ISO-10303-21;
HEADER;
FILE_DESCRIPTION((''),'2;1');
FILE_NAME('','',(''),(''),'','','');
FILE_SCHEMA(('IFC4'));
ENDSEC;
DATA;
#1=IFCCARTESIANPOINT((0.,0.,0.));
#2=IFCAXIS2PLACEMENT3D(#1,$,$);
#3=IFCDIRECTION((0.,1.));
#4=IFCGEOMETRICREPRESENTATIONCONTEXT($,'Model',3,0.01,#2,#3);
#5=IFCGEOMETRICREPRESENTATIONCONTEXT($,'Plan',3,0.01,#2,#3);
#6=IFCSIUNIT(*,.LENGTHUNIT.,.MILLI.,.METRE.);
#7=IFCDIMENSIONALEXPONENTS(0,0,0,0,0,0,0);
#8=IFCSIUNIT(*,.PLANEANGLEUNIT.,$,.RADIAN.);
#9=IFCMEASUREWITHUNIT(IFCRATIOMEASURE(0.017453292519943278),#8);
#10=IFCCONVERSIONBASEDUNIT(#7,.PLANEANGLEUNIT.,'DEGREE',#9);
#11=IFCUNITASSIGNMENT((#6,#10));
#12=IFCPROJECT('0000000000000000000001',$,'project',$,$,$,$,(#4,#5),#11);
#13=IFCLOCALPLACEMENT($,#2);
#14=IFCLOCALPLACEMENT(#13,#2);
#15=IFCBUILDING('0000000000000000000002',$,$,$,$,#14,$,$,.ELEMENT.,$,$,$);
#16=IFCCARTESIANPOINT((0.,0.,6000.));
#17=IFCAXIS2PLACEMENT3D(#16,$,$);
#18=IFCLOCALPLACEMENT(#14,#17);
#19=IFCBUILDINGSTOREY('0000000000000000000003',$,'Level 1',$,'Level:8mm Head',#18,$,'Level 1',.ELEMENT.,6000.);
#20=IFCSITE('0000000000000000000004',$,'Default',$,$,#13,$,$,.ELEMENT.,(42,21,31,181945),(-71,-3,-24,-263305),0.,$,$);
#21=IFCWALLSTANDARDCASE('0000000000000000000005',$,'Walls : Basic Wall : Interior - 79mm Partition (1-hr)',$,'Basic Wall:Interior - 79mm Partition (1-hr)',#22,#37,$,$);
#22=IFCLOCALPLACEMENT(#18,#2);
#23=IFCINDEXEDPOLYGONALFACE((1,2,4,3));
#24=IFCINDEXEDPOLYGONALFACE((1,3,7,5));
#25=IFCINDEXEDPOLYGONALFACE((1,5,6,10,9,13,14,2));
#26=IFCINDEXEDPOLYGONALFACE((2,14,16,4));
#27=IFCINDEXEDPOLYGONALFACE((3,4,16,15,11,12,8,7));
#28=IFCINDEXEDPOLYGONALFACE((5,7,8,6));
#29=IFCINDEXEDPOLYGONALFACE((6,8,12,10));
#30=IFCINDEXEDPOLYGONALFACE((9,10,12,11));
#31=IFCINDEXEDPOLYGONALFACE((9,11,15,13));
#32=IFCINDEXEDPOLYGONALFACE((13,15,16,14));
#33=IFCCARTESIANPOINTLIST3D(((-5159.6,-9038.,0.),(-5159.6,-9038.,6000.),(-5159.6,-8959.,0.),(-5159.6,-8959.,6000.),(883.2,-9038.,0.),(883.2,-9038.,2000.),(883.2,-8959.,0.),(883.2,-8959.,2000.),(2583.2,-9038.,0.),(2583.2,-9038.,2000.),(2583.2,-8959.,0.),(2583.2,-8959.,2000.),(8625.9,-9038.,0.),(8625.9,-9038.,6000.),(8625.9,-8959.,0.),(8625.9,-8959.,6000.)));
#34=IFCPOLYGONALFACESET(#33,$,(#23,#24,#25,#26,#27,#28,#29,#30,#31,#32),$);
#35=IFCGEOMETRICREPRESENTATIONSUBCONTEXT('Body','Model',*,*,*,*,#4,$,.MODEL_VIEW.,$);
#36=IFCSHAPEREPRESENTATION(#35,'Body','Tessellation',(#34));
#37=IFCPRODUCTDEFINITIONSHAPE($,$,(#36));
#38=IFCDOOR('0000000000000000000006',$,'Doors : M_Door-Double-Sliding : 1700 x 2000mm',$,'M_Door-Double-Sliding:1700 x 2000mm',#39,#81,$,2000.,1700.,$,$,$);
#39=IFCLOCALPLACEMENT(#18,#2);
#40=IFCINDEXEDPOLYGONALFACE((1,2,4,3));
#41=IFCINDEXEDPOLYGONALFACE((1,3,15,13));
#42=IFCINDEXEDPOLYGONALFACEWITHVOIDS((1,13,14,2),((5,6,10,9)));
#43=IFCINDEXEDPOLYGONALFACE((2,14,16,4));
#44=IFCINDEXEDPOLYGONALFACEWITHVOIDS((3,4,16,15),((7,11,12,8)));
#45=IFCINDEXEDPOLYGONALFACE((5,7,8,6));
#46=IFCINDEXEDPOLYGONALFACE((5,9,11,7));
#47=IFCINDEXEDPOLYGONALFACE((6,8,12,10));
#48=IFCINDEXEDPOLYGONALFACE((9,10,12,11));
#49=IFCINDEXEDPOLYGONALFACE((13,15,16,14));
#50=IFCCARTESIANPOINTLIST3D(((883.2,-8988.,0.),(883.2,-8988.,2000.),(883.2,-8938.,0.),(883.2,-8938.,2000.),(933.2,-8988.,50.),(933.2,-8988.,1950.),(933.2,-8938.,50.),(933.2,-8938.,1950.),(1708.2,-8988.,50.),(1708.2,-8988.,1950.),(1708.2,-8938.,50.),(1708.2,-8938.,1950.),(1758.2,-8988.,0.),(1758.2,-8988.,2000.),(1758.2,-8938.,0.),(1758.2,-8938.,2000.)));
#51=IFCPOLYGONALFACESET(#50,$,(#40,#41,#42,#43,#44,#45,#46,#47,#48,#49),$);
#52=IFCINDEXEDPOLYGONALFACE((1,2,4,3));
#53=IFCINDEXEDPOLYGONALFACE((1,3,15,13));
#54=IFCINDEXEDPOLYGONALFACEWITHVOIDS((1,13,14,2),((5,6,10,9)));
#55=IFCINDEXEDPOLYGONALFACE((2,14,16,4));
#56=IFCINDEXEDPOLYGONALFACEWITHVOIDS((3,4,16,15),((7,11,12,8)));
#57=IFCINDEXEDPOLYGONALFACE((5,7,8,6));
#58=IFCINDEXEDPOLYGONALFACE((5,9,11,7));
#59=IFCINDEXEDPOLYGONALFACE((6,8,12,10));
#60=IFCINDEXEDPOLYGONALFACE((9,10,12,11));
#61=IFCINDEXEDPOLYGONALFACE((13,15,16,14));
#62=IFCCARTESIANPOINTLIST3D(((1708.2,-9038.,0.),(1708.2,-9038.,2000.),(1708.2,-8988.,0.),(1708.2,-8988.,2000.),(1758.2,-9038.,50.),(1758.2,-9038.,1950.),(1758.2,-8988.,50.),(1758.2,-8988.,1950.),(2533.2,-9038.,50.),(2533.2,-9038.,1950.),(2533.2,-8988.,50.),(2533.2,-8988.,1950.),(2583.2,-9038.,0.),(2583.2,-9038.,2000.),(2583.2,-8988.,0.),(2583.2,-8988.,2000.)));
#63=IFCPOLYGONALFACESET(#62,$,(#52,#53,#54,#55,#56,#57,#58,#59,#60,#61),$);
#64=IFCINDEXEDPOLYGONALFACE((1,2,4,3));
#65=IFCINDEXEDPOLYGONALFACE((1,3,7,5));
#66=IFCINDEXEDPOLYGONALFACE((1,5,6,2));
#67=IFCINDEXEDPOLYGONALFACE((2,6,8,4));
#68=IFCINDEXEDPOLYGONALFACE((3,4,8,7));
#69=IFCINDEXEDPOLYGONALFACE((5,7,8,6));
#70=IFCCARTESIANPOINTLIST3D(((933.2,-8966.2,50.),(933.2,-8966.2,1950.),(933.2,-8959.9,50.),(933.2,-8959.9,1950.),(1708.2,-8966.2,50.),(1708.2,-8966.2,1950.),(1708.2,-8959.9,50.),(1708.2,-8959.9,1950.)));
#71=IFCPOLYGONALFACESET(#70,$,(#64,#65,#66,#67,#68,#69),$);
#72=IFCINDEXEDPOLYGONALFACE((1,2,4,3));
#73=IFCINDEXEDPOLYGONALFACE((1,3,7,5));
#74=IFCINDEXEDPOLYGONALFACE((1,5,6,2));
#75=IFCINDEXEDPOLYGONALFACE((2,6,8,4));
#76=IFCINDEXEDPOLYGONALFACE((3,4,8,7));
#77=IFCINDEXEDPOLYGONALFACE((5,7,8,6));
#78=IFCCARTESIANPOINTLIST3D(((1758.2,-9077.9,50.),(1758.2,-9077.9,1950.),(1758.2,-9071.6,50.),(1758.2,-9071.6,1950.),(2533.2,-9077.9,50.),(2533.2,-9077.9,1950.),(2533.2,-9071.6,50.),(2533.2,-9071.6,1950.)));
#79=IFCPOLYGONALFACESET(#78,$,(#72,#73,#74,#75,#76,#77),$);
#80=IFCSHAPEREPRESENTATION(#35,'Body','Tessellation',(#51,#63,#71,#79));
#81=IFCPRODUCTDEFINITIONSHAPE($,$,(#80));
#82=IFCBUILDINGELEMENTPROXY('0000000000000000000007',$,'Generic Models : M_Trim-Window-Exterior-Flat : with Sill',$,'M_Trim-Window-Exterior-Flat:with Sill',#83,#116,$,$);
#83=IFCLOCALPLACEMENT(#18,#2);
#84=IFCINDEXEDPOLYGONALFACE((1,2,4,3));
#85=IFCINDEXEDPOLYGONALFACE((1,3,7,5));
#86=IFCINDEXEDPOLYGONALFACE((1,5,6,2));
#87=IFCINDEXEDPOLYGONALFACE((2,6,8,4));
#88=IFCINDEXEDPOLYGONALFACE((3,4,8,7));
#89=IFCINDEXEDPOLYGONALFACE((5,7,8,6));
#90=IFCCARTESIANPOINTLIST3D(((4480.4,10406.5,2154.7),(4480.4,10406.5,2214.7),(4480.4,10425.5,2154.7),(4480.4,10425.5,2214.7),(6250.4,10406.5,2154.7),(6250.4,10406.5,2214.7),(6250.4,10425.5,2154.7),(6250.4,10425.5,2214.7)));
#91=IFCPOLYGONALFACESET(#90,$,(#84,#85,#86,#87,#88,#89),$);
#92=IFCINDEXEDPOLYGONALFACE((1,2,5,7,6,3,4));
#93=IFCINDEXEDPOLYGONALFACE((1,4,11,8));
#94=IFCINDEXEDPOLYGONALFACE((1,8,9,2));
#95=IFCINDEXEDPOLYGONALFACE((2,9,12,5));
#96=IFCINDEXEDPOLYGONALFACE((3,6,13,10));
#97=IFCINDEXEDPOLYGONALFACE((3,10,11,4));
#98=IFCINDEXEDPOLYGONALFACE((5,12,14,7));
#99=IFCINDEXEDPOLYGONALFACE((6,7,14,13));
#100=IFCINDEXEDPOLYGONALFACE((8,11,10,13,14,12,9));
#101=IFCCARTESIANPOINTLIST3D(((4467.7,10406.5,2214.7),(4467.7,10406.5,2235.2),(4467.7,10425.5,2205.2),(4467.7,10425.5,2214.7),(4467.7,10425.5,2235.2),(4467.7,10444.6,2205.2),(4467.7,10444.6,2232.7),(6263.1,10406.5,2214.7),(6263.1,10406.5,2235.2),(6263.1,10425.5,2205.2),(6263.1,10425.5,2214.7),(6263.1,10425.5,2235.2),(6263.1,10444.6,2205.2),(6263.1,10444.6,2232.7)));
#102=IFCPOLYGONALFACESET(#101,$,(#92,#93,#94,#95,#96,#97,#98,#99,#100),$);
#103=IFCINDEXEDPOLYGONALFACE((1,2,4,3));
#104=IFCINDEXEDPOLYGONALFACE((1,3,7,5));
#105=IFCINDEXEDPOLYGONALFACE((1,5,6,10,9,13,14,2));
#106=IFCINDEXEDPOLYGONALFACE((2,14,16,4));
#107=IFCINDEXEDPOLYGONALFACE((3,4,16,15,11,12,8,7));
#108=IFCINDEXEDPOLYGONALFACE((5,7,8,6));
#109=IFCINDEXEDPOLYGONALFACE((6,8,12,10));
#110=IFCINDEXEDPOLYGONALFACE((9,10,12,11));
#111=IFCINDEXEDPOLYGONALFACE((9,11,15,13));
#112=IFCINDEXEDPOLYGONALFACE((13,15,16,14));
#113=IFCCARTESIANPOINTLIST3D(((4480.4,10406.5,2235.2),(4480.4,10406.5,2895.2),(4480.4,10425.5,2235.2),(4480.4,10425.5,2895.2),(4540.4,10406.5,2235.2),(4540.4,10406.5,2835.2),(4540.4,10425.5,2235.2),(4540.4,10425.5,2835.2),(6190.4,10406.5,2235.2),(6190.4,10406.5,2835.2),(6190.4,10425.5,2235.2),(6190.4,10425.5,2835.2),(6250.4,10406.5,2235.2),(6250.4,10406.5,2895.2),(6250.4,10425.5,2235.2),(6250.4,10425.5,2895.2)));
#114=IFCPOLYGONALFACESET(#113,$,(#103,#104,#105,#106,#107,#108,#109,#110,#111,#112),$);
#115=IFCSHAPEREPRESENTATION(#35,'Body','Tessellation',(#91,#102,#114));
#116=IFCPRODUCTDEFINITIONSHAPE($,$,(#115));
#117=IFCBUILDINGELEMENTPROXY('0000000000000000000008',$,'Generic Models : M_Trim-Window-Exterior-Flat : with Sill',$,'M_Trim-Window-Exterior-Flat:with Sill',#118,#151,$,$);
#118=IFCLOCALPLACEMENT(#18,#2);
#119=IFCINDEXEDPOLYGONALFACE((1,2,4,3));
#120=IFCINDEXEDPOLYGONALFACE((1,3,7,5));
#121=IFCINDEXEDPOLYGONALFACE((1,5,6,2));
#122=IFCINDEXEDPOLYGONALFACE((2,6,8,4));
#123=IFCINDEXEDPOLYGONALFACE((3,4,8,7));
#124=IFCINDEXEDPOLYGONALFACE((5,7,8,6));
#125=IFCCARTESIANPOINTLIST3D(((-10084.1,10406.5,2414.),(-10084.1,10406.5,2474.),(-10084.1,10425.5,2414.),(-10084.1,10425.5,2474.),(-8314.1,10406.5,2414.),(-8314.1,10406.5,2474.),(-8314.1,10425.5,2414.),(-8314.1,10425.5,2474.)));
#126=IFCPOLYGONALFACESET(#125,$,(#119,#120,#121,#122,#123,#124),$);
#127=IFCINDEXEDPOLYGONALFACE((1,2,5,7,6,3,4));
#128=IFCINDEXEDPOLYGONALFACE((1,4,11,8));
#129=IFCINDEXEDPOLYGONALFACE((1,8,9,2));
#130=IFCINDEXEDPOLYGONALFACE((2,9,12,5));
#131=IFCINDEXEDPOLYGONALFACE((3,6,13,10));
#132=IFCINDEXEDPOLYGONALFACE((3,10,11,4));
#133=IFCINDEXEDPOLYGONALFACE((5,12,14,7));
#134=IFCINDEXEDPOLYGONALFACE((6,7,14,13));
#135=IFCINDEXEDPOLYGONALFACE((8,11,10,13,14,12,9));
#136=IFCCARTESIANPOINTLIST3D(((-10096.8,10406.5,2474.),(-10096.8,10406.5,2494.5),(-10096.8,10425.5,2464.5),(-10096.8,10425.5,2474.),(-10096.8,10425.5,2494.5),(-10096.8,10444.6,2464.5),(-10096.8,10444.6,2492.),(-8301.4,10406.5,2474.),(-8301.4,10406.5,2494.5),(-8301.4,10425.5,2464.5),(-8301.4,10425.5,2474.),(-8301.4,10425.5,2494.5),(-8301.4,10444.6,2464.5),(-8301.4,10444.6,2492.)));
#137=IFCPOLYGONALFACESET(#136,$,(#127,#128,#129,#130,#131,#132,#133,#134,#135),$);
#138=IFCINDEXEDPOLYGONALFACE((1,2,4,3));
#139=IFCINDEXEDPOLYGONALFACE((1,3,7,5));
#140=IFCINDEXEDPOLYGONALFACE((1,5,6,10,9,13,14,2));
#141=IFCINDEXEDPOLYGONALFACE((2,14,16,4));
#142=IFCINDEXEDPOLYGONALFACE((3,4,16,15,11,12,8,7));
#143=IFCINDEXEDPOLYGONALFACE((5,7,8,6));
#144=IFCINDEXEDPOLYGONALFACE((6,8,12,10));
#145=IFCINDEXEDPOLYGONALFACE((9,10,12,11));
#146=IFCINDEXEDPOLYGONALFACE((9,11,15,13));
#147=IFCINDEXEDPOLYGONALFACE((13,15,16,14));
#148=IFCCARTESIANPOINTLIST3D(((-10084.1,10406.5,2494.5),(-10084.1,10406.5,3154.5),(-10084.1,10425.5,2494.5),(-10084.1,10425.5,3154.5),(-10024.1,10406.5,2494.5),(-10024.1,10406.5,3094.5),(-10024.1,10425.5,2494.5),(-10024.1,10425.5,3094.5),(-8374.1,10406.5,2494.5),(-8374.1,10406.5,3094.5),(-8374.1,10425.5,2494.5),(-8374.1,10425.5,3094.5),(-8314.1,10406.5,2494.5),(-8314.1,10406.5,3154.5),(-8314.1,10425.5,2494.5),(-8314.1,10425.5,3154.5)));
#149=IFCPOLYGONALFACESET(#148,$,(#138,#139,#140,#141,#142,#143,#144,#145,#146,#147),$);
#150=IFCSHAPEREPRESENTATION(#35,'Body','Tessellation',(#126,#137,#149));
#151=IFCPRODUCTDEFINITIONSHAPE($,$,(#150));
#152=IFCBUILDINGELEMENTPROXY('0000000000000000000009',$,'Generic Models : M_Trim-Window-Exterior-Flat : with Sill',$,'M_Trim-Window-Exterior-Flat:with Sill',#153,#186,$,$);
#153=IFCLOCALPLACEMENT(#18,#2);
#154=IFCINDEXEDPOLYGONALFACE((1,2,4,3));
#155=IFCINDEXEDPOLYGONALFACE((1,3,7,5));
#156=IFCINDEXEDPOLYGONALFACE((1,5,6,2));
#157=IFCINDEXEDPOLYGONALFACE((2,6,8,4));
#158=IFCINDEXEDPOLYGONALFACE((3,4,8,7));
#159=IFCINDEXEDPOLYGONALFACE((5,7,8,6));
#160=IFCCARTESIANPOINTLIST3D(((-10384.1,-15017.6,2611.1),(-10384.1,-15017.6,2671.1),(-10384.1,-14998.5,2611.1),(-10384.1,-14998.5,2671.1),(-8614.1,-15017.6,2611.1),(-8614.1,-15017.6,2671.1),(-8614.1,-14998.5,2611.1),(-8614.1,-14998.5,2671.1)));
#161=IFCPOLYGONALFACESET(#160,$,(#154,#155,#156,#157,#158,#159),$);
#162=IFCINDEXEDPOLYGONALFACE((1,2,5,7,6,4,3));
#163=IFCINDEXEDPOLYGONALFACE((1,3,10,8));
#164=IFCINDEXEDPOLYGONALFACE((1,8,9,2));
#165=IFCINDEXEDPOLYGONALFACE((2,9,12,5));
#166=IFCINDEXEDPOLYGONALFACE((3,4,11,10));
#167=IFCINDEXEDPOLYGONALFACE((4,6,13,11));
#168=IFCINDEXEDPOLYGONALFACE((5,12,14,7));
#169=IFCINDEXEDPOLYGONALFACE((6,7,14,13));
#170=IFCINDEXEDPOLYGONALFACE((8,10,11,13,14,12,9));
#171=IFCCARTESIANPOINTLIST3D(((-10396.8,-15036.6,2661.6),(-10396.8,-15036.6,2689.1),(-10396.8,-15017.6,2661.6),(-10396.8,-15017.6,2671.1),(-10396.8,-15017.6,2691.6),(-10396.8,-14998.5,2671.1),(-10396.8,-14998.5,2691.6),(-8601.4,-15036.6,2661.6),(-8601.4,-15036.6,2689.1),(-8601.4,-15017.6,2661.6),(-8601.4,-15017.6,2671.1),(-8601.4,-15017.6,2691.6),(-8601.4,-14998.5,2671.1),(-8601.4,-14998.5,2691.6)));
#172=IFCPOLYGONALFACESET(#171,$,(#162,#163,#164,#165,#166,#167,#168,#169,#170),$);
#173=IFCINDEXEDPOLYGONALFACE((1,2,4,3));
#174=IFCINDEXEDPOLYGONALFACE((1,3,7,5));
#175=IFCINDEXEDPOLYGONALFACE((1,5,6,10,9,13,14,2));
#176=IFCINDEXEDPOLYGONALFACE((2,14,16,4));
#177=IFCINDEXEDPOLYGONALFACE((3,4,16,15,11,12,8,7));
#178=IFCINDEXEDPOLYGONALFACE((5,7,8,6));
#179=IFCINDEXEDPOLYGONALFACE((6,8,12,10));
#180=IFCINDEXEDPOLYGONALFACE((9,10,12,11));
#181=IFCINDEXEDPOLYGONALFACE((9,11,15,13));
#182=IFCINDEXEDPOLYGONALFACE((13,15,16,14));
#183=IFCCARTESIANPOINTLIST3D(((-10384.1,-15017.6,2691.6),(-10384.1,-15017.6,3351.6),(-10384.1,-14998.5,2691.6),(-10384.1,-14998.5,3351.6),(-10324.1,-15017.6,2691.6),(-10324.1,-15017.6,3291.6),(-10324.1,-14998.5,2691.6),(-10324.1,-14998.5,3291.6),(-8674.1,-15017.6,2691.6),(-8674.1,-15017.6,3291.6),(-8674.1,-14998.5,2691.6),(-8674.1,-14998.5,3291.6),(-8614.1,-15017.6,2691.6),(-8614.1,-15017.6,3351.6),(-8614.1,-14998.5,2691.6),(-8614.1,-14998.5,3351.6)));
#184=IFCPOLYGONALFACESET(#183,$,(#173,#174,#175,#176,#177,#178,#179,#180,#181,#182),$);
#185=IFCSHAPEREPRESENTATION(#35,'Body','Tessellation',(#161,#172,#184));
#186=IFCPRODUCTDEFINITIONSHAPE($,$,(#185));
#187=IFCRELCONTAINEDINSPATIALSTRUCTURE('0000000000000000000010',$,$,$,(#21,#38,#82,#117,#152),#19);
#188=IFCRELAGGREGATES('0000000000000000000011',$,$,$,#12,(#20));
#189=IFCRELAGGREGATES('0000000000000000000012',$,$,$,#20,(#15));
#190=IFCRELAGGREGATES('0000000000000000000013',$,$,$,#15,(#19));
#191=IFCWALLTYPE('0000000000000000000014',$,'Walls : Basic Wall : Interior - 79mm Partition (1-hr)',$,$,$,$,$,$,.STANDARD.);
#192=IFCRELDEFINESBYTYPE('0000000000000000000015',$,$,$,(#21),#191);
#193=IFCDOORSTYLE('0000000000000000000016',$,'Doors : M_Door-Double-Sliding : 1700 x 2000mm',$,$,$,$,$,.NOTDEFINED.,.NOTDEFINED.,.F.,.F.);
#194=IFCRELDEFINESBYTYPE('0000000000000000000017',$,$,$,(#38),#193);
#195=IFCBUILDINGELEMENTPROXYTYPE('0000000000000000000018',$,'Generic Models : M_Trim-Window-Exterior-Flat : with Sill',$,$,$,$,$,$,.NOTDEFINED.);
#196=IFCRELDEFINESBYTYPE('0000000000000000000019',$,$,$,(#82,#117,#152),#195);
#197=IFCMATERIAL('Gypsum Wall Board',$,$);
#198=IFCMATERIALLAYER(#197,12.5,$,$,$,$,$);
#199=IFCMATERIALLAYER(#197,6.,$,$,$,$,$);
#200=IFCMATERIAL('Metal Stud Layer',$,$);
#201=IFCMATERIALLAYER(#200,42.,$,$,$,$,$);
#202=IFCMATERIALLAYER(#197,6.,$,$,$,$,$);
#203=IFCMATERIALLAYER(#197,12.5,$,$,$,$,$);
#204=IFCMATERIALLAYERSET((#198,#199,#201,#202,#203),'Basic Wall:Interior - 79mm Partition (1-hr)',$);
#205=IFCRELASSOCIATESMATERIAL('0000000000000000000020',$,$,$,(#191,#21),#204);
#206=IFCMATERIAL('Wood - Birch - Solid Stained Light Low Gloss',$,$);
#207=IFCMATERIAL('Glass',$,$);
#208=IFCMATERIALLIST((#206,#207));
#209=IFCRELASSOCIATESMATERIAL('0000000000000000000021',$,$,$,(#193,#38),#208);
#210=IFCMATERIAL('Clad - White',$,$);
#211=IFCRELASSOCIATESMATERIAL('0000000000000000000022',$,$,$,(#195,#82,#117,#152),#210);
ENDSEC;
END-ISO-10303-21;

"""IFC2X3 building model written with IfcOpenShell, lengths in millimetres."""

from ifc_helpers import new_model, entity, si_unit, converted_unit, direction, frame, frame_2d, origin, origin_2d_with_axis, place, context, subcontext, project, spatial, polyline, rectangle, outline, extrude, source, transform, mapped, material, material_list, layer, layer_set, layer_usage, type_object, type_shapes, element, fill, save


model = new_model("IFC2X3")

# Units and contexts
model_context = context("Model", 3, precision=0.01, world=origin(), true_north=direction((0.0, 1.0)))
plan_context = context("Plan", 3, precision=0.01, world=origin(), true_north=direction((0.0, 1.0)))
body_context = subcontext(model_context, "Body", "Model", "MODEL_VIEW")
ifc_project = project(units=[si_unit("LENGTHUNIT", "METRE", prefix="MILLI"), converted_unit("PLANEANGLEUNIT", "DEGREE", entity("IfcRatioMeasure", 0.017453292519943278), si_unit("PLANEANGLEUNIT", "RADIAN"), dimensions=[0, 0, 0, 0, 0, 0, 0])], contexts=[model_context, plan_context])

# Site, building, storey
site_placement = place(None, origin())
site = spatial("IfcSite", under=ifc_project, at=site_placement, Name="Default", CompositionType="ELEMENT", RefLatitude=(42, 21, 31, 181945), RefLongitude=(-71, -3, -24, -263305), RefElevation=0.0)
building_placement = place(site_placement, origin())
building = spatial("IfcBuilding", under=site, at=building_placement, CompositionType="ELEMENT")
storey_placement = place(building_placement, frame((0.0, 0.0, 6000.0)))
storey = spatial("IfcBuildingStorey", under=building, at=storey_placement, Name="Level 1", ObjectType="Level:8mm Head", LongName="Level 1", CompositionType="ELEMENT", Elevation=6000.0)

# Shared definitions
ifc_material_1 = material(Name="Gypsum Wall Board")
ifc_layer_1 = layer(ifc_material_1, 12.5)
ifc_layer_2 = layer(ifc_material_1, 6.0)
ifc_material_2 = material(Name="Metal Stud Layer")
ifc_layer_3 = layer(ifc_material_2, 42.0)
ifc_layer_4 = layer(ifc_material_1, 6.0)
ifc_layer_5 = layer(ifc_material_1, 12.5)
ifc_layer_set_1 = layer_set([ifc_layer_1, ifc_layer_2, ifc_layer_3, ifc_layer_4, ifc_layer_5], Name="Basic Wall:Interior - 79mm Partition (1-hr)")
ifc_layer_usage_1 = layer_usage(ifc_layer_set_1, "AXIS2", "NEGATIVE", 39.5)
wall_type = type_object("IfcWallType", Name="Walls : Basic Wall : Interior - 79mm Partition (1-hr)", PredefinedType="STANDARD", material=ifc_layer_set_1)

# Wall, opening, door
ifc_material_3 = material(Name="Wood - Birch - Solid Stained Light Low Gloss")
ifc_material_4 = material(Name="Glass")
ifc_material_list = material_list([ifc_material_3, ifc_material_4])
door_style = type_object("IfcDoorStyle", Name="Doors : M_Door-Double-Sliding : 1700 x 2000mm", ConstructionType="NOTDEFINED", OperationType="NOTDEFINED", ParameterTakesPrecedence=False, Sizeable=False, material=ifc_material_list)
shared_shape_1 = source(origin(), body_context, "Body", "SweptSolid", [
    extrude(outline(polyline([(-437.5, -1000.0), (437.5, -1000.0), (437.5, 1000.0), (-437.5, 1000.0), (-437.5, -1000.0)]), holes=[polyline([(-387.5, -950.0), (-387.5, 950.0), (387.5, 950.0), (387.5, -950.0), (-387.5, -950.0)])]), frame((1262.5, -21.0, 1000.0), z_axis=(0.0, 1.0, 0.0), x_axis=(1.0, 0.0, 0.0)), (0.0, 0.0, 1.0), 50.0),
    extrude(outline(polyline([(-1000.0, -437.5), (1000.0, -437.5), (1000.0, 437.5), (-1000.0, 437.5), (-1000.0, -437.5)]), holes=[polyline([(-950.0, -387.5), (-950.0, 387.5), (950.0, 387.5), (950.0, -387.5), (-950.0, -387.5)])]), frame((437.5, 29.0, 1000.0), z_axis=(0.0, 1.0, 0.0), x_axis=(0.0, 0.0, -1.0)), (0.0, 0.0, 1.0), 50.0),
    extrude(rectangle(XDim=6.3, YDim=775.0, at=frame_2d((0.0, 0.0), x_axis=(1.0, 0.0))), frame((1262.5, 4.0, 50.0), z_axis=(0.0, 0.0, 1.0), x_axis=(0.0, -1.0, 0.0)), (0.0, 0.0, 1.0), 1900.0),
    extrude(rectangle(XDim=6.4, YDim=775.0, at=origin_2d_with_axis()), frame((437.5, 115.7, 50.0), z_axis=(0.0, 0.0, 1.0), x_axis=(0.0, 1.0, 0.0)), (0.0, 0.0, 1.0), 1900.0),
])
type_shapes(door_style, [shared_shape_1])
wall_1_placement = place(storey_placement, frame((-5159.6, -8998.5, 0.0)))
wall_1 = element("IfcWallStandardCase", 1, at=wall_1_placement, inside=storey, type_object=wall_type, material=ifc_layer_usage_1, Name="Walls : Basic Wall : Interior - 79mm Partition (1-hr)", ObjectType="Basic Wall:Interior - 79mm Partition (1-hr)", context=body_context, shape_type="SweptSolid", body=[
    extrude(rectangle(XDim=13785.5, YDim=79.0, at=frame_2d((6892.8, 0.0), x_axis=(1.0, 0.0))), origin(), (0.0, 0.0, 1.0), 6000.0),
])
opening_1_placement = place(wall_1_placement, frame((7742.8, 39.5, 0.0)))
opening_1 = element("IfcOpeningElement", 2, at=opening_1_placement, cuts=wall_1, ObjectType="Opening", context=body_context, shape_type="SweptSolid", body=[
    extrude(rectangle(XDim=2000.0, YDim=1700.0, at=frame_2d((1000.0, 850.0), x_axis=(-1.0, 0.0))), frame((0.0, 0.0, 0.0), z_axis=(0.0, -1.0, 0.0), x_axis=(0.0, 0.0, 1.0)), (0.0, 0.0, 1.0), 79.0),
])
door_1_placement = place(opening_1_placement, frame((0.0, 0.0, 0.0), z_axis=(0.0, 0.0, 1.0), x_axis=(-1.0, 0.0, 0.0)))
door_1 = element("IfcDoor", 3, at=door_1_placement, inside=storey, type_object=door_style, material=ifc_material_list, Name="Doors : M_Door-Double-Sliding : 1700 x 2000mm", ObjectType="M_Door-Double-Sliding:1700 x 2000mm", OverallHeight=2000.0, OverallWidth=1700.0, context=body_context, shape_type="MappedRepresentation", body=[
    mapped(shared_shape_1, transform((0.0, 0.0, 0.0), scale=1.0)),
])
fill(opening_1, door_1)

# Building element proxies
ifc_material_5 = material(Name="Clad - White")
building_element_proxy_type_1 = type_object("IfcBuildingElementProxyType", Name="Generic Models : M_Trim-Window-Exterior-Flat : with Sill", PredefinedType="NOTDEFINED", material=ifc_material_5)
shared_shape_2 = source(origin(), body_context, "Body", "SweptSolid", [
    extrude(rectangle(XDim=1770.0, YDim=60.0, at=frame_2d((0.0, 0.0), x_axis=(1.0, 0.0))), frame((0.0, -650.4, 0.0), z_axis=(0.0, 0.0, 1.0), x_axis=(-1.0, 0.0, 0.0)), (0.0, 0.0, 1.0), 19.0),
    extrude(outline(polyline([(-19.0, -15.2), (0.0, -15.2), (0.0, -5.7), (19.0, -5.7), (19.0, 14.8), (0.0, 14.8), (-19.0, 12.3), (-19.0, -15.2)])), frame((-897.7, -614.8, 19.0), z_axis=(1.0, 0.0, 0.0), x_axis=(0.0, 0.0, -1.0)), (0.0, 0.0, 1.0), 1795.4),
    extrude(outline(polyline([(-345.0, -885.0), (315.0, -885.0), (315.0, -825.0), (-285.0, -825.0), (-285.0, 825.0), (315.0, 825.0), (315.0, 885.0), (-345.0, 885.0), (-345.0, -885.0)])), frame((0.0, -285.0, 0.0), z_axis=(0.0, 0.0, 1.0), x_axis=(0.0, -1.0, 0.0)), (0.0, 0.0, 1.0), 19.0),
])
type_shapes(building_element_proxy_type_1, [shared_shape_2])
for number, where, z_axis, x_axis, name in (
    (4, (5365.4, 10406.5, 2835.2), (0.0, 1.0, 0.0), (-1.0, 0.0, 0.0), "Generic Models : M_Trim-Window-Exterior-Flat : with Sill"),
    (5, (-9199.1, 10406.5, 3094.5), (0.0, 1.0, 0.0), (-1.0, 0.0, 0.0), "Generic Models : M_Trim-Window-Exterior-Flat : with Sill"),
    (6, (-9499.1, -14998.5, 3291.6), (0.0, -1.0, 0.0), (1.0, 0.0, 0.0), "Generic Models : M_Trim-Window-Exterior-Flat : with Sill"),
):
    element("IfcBuildingElementProxy", number, at=place(storey_placement, frame(where, z_axis=z_axis, x_axis=x_axis)), inside=storey, type_object=building_element_proxy_type_1, material=ifc_material_5, Name=name, ObjectType="M_Trim-Window-Exterior-Flat:with Sill", context=body_context, shape_type="MappedRepresentation", body=[
        mapped(shared_shape_2, transform((0.0, 0.0, 0.0), scale=1.0)),
    ])

save(model, "model.ifc")
